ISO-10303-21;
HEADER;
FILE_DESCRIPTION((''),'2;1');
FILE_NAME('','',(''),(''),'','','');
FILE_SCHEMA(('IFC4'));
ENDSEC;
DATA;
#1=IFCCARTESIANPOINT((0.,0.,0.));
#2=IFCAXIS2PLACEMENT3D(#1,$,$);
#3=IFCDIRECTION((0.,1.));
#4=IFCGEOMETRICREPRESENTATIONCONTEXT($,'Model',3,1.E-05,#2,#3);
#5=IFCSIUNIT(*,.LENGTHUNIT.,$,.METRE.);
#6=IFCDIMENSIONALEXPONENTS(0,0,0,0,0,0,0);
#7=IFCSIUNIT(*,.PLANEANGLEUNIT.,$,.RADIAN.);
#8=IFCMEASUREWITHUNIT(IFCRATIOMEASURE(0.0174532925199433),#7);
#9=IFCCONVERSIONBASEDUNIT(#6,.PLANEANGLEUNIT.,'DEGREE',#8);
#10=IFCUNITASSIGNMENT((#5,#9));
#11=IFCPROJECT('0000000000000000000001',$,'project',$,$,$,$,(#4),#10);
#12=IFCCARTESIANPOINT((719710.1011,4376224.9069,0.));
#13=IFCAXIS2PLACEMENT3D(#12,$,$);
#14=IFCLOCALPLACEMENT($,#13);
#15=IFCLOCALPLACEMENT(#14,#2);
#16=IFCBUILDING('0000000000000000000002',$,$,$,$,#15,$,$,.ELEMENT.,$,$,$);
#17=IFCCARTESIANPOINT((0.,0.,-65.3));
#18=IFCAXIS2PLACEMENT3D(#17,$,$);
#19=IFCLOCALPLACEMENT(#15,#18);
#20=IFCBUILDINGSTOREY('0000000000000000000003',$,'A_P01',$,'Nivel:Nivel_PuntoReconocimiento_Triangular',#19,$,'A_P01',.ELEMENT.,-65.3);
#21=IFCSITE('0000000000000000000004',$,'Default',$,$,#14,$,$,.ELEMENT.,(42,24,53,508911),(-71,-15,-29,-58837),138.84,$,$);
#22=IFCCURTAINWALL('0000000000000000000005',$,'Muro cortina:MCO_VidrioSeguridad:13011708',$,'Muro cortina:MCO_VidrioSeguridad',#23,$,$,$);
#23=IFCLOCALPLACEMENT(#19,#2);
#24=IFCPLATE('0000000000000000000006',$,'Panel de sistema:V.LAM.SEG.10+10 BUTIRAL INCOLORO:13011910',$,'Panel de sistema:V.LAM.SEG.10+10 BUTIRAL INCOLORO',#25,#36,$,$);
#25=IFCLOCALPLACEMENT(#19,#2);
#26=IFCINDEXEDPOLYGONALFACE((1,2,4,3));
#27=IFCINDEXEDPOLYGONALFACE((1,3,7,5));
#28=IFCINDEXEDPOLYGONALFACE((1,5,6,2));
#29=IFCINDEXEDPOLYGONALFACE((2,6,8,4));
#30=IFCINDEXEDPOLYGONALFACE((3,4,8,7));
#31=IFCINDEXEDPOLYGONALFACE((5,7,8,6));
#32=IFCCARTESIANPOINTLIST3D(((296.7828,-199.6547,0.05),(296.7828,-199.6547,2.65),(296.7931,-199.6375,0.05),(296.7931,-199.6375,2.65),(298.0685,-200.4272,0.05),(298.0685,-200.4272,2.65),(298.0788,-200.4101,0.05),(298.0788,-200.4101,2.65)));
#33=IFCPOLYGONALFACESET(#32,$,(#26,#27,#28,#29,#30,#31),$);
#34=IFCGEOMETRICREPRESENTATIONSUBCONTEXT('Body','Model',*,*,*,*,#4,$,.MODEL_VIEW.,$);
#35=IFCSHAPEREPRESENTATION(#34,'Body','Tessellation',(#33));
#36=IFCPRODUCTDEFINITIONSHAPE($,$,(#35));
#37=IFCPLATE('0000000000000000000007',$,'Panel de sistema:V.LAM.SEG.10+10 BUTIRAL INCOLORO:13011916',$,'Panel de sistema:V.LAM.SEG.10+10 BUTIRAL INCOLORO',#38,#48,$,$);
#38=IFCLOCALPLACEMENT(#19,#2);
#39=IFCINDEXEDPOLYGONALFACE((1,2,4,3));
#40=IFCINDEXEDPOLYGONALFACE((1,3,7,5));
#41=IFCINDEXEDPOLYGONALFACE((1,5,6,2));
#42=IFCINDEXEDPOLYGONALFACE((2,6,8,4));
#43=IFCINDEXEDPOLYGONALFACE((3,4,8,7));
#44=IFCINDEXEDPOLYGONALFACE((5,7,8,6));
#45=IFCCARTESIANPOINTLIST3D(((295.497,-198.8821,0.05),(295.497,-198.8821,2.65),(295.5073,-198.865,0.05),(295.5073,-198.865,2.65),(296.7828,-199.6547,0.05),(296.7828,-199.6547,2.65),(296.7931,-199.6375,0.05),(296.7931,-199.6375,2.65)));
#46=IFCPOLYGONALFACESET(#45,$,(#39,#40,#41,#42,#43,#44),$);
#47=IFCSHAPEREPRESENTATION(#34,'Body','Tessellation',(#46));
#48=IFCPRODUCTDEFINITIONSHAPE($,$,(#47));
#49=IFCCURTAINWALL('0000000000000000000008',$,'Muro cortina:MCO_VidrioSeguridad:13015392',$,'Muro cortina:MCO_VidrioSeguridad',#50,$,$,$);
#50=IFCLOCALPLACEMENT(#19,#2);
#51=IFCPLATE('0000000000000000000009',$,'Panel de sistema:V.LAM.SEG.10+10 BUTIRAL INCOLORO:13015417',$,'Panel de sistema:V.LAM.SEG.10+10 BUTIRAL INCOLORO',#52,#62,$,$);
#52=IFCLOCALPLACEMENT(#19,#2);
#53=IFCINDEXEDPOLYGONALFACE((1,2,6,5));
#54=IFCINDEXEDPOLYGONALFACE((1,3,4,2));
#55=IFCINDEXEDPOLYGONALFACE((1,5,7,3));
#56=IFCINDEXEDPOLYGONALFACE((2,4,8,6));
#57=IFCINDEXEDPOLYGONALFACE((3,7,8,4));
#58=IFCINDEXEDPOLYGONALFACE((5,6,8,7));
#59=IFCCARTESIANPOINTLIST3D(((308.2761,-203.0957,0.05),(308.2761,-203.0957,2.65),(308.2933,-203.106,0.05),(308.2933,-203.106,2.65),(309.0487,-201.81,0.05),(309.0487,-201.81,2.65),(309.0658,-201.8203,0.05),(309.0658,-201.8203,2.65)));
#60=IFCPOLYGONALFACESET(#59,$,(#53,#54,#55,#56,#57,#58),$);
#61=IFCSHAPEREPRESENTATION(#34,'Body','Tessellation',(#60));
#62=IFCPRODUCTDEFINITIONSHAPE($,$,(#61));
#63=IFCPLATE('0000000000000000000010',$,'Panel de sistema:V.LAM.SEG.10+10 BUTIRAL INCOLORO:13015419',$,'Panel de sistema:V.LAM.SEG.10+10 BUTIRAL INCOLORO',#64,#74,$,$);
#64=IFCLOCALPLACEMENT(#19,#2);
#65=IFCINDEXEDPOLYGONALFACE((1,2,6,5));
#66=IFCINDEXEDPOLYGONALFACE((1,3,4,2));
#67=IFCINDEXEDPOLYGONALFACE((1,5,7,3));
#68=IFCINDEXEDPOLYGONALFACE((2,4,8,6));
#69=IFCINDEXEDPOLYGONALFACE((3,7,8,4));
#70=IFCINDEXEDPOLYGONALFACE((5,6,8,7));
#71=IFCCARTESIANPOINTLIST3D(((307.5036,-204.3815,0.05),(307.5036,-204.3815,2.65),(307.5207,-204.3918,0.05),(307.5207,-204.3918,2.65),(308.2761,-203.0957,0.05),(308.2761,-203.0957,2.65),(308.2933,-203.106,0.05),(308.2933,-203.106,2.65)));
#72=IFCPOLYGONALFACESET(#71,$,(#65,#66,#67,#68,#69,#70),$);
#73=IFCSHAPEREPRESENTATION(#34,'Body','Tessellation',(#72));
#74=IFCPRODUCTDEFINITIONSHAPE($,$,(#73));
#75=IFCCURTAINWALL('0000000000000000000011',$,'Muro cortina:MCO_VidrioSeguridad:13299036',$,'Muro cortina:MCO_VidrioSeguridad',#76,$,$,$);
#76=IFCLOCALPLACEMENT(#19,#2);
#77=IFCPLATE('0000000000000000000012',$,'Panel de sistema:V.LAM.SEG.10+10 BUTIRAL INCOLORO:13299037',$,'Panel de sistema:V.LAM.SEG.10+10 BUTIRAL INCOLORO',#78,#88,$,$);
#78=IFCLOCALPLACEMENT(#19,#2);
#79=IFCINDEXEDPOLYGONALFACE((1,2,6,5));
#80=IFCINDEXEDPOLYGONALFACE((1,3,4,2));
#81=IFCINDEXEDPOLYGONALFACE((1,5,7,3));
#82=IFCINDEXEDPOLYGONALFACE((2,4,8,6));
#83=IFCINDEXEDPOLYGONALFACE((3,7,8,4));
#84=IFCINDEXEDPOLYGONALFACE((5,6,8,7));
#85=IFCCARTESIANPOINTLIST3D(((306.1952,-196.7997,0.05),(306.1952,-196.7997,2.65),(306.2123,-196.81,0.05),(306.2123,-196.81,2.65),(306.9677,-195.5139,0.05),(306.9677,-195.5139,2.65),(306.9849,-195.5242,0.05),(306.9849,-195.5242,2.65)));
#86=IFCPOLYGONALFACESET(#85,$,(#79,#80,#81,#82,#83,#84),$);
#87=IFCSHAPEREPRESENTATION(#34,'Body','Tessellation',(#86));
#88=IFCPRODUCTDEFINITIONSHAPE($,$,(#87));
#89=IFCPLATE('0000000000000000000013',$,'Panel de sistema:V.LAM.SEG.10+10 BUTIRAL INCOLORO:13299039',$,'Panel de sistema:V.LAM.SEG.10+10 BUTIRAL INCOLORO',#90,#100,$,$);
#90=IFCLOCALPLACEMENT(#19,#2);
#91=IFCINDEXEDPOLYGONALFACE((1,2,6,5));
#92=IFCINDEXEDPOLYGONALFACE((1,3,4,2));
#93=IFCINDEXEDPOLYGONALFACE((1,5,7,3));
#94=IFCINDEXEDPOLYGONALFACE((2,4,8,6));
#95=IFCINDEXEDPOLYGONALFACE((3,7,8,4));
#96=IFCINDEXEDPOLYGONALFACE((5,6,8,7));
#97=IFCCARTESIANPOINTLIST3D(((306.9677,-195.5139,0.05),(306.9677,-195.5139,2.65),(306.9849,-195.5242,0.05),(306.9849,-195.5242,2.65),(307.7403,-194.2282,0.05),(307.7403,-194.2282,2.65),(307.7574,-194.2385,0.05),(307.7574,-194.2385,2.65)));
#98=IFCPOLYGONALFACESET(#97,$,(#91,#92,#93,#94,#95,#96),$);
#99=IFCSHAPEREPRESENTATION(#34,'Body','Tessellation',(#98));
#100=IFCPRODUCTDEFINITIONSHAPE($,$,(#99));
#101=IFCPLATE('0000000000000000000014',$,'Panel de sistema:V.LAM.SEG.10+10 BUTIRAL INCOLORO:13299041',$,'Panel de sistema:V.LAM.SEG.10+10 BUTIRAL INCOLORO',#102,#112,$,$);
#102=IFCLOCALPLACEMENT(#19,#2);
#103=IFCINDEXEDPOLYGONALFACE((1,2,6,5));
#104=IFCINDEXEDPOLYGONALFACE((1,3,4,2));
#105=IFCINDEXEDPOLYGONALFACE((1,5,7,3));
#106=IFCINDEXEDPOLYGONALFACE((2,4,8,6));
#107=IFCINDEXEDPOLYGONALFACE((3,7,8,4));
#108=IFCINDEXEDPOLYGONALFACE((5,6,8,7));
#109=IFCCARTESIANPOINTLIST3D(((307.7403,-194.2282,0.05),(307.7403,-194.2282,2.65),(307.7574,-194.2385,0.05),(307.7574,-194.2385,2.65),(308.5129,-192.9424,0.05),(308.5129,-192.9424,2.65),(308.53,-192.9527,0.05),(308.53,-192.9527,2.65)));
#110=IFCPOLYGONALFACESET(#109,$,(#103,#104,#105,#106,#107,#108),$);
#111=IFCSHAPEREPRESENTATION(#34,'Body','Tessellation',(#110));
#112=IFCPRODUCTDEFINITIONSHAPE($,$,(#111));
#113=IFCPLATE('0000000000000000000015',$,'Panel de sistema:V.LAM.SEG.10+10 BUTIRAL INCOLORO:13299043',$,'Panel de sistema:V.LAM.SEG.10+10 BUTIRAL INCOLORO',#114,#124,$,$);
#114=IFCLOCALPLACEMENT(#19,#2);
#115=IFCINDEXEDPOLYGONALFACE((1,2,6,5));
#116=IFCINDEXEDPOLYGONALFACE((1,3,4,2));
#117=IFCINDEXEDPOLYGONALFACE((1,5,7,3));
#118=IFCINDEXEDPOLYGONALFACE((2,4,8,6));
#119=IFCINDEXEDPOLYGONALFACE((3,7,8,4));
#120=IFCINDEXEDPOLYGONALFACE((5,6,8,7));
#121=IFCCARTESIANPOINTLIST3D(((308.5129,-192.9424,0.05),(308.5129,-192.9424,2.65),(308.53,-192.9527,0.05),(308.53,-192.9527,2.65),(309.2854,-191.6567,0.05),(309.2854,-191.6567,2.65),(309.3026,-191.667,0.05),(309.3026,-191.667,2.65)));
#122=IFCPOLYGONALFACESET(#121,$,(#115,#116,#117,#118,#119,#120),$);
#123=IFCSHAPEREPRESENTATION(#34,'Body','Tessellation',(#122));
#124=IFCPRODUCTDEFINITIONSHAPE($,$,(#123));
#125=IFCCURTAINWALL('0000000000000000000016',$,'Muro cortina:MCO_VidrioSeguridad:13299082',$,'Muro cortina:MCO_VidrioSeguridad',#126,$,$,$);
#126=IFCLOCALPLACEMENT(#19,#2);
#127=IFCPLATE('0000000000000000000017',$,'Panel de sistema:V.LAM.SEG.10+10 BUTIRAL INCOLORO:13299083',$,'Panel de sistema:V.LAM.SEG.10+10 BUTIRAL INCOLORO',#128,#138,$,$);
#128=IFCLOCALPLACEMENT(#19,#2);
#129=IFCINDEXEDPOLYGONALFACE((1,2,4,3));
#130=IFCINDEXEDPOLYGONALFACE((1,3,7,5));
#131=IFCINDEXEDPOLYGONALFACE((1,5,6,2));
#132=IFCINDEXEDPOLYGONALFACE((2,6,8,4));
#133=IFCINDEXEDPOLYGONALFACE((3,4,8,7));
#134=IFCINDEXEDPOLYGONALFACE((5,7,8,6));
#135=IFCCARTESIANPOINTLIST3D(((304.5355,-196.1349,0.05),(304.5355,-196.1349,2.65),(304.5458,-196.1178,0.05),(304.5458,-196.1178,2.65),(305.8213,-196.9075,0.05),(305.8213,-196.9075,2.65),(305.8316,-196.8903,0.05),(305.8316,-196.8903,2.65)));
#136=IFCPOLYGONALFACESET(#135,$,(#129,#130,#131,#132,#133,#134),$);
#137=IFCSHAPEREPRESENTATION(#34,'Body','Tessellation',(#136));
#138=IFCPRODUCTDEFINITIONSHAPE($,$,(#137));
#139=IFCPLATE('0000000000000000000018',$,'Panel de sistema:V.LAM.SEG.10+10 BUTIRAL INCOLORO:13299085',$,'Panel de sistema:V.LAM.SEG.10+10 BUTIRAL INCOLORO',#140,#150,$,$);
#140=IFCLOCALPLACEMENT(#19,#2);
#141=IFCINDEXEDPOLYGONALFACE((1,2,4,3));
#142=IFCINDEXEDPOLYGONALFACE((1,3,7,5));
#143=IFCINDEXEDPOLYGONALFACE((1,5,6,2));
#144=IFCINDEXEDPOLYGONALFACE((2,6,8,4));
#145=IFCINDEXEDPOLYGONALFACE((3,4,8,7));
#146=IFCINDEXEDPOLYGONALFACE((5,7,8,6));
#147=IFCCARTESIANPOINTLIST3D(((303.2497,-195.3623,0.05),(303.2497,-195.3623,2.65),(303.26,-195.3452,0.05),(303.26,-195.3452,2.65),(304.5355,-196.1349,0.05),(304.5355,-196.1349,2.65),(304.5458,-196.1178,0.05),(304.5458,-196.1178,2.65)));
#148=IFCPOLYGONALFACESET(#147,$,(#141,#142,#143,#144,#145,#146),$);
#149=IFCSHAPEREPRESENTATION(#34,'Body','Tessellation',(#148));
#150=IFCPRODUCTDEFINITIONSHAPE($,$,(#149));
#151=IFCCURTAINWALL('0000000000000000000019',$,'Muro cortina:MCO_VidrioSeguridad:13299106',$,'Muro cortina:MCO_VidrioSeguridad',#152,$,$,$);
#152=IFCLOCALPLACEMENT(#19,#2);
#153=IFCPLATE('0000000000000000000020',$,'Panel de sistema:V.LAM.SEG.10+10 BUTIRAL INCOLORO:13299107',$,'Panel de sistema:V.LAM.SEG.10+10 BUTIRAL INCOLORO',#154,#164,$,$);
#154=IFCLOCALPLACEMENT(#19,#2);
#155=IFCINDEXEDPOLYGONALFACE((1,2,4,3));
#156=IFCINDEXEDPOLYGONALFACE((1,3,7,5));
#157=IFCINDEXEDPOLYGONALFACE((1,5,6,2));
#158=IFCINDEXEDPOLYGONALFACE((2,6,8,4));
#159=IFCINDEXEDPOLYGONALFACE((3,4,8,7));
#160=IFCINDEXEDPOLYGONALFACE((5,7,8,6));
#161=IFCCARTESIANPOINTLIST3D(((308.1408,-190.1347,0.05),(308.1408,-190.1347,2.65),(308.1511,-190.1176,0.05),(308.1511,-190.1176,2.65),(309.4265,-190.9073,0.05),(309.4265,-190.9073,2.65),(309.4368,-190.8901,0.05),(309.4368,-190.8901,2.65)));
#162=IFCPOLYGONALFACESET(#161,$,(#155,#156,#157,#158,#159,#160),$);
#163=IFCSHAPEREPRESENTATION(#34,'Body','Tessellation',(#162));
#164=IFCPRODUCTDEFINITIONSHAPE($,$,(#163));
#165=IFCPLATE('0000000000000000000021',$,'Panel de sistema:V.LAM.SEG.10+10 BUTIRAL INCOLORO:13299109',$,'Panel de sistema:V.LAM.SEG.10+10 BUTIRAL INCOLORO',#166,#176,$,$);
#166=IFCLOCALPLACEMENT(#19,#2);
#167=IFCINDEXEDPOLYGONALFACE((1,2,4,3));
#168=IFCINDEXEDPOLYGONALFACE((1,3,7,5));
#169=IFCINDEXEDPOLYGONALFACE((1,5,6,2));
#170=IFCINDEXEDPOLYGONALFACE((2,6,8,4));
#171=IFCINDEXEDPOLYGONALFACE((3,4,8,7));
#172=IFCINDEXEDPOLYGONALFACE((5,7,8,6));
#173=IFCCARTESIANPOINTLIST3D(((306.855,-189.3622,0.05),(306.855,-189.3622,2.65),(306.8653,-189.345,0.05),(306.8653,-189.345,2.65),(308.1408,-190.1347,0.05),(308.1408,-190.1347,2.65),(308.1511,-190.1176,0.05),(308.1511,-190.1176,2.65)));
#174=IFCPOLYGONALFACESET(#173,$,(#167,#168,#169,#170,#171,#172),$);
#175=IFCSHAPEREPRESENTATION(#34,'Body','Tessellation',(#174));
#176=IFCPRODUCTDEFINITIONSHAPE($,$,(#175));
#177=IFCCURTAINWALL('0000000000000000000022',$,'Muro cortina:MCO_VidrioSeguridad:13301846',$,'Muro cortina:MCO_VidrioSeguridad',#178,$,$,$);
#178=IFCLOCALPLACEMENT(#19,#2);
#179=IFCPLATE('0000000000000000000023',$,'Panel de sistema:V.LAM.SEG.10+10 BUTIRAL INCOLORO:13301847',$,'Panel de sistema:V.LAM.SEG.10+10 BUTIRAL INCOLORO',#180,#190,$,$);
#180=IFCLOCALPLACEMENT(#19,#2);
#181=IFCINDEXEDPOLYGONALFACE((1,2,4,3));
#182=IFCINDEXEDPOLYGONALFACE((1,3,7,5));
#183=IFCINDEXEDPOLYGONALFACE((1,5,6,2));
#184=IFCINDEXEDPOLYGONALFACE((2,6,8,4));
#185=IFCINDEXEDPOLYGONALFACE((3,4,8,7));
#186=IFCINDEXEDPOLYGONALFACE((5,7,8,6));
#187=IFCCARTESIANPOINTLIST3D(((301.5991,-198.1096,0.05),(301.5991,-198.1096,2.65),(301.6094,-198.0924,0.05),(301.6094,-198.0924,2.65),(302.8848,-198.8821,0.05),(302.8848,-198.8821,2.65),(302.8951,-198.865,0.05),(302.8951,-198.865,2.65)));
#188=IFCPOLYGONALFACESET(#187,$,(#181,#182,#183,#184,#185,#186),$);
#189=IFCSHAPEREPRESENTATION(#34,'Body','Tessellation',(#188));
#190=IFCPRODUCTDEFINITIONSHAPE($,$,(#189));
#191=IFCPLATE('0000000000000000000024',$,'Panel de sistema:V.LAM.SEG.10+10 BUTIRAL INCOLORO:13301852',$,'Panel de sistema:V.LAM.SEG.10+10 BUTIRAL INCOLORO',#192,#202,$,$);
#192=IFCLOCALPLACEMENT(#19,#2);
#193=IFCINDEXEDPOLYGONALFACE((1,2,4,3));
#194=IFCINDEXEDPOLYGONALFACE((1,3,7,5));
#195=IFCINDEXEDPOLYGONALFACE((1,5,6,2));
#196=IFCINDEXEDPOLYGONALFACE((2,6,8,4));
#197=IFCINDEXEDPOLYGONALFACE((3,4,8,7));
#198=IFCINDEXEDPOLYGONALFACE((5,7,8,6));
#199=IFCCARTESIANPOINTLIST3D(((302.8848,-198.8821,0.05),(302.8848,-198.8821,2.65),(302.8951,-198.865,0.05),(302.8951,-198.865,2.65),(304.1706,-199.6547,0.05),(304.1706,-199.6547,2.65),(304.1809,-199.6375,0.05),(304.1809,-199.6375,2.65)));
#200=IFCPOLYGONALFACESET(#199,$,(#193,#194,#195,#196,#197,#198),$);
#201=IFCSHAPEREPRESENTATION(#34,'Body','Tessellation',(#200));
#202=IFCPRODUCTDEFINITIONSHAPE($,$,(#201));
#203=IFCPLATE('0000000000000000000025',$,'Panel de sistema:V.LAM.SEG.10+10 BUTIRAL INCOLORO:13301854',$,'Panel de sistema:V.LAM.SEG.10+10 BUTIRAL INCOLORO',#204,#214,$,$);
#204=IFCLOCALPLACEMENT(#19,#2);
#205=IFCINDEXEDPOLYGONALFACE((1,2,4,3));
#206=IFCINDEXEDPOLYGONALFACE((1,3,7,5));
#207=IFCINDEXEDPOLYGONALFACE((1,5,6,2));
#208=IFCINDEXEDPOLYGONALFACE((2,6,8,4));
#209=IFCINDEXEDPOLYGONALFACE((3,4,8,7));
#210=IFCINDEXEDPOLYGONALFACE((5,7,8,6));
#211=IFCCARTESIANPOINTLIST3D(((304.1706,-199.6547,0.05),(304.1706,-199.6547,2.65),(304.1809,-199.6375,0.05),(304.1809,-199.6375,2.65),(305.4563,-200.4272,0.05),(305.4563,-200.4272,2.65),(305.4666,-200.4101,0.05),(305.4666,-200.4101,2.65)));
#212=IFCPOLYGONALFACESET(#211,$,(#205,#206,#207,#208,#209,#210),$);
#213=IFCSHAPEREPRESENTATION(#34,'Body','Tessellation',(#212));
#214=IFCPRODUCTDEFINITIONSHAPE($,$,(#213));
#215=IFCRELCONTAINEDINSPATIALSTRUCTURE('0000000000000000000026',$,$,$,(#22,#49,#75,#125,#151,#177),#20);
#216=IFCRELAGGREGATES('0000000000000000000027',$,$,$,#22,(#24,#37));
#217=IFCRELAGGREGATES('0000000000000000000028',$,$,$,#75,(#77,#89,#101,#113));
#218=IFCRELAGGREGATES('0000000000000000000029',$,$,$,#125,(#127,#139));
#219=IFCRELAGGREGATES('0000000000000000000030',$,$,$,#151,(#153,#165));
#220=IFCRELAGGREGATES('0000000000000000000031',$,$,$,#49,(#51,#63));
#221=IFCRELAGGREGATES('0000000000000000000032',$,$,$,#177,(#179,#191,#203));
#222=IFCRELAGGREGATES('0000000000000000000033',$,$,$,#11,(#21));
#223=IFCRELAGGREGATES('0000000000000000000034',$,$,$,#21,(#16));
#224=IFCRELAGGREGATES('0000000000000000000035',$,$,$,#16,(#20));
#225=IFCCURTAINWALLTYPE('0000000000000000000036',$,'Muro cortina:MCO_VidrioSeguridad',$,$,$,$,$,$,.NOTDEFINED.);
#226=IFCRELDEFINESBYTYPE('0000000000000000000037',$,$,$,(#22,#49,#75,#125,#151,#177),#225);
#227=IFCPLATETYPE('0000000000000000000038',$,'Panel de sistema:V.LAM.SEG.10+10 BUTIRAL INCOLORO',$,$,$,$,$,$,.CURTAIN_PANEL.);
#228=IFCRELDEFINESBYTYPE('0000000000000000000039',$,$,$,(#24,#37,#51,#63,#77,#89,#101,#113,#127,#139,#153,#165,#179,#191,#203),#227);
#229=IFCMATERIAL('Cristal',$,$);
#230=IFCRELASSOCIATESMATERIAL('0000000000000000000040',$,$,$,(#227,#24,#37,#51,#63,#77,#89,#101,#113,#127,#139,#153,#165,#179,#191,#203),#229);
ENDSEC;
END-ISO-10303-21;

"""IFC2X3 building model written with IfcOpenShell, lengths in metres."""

from ifc_helpers import new_model, entity, si_unit, converted_unit, direction, frame, origin, origin_2d_with_axis, place, context, subcontext, project, spatial, rectangle, extrude, source, transform, mapped, material, type_object, type_shapes, element, aggregate, save


model = new_model("IFC2X3")

# Units and contexts
model_context = context("Model", 3, precision=1e-05, world=origin(), true_north=direction((0.0, 1.0)))
body_context = subcontext(model_context, "Body", "Model", "MODEL_VIEW")
ifc_project = project(units=[si_unit("LENGTHUNIT", "METRE"), converted_unit("PLANEANGLEUNIT", "DEGREE", entity("IfcRatioMeasure", 0.0174532925199433), si_unit("PLANEANGLEUNIT", "RADIAN"), dimensions=[0, 0, 0, 0, 0, 0, 0])], contexts=[model_context])

# Site, building, storey
site_placement = place(None, frame((719710.1011, 4376224.9069, 0.0)))
site = spatial("IfcSite", under=ifc_project, at=site_placement, Name="Default", CompositionType="ELEMENT", RefLatitude=(42, 24, 53, 508911), RefLongitude=(-71, -15, -29, -58837), RefElevation=138.84)
building_placement = place(site_placement, origin())
building = spatial("IfcBuilding", under=site, at=building_placement, CompositionType="ELEMENT")
storey_placement = place(building_placement, frame((0.0, 0.0, -65.3)))
storey = spatial("IfcBuildingStorey", under=building, at=storey_placement, Name="A_P01", ObjectType="Nivel:Nivel_PuntoReconocimiento_Triangular", LongName="A_P01", CompositionType="ELEMENT", Elevation=-65.3)

# Curtain walls, plates
curtain_wall_type = type_object("IfcCurtainWallType", Name="Muro cortina:MCO_VidrioSeguridad", PredefinedType="NOTDEFINED")
curtain_wall_1_placement = place(storey_placement, frame((0.0, 0.0, 65.3)))
curtain_wall_1 = element("IfcCurtainWall", 1, at=curtain_wall_1_placement, inside=storey, type_object=curtain_wall_type, Name="Muro cortina:MCO_VidrioSeguridad:13011708", ObjectType="Muro cortina:MCO_VidrioSeguridad")
ifc_material_1 = material(Name="Cristal")
plate_type_1 = type_object("IfcPlateType", Name="Panel de sistema:V.LAM.SEG.10+10 BUTIRAL INCOLORO", PredefinedType="CURTAIN_PANEL", material=ifc_material_1)
shared_shape_1 = source(origin(), body_context, "Body", "SweptSolid", [
    extrude(rectangle(XDim=0.02, YDim=1.5, at=origin_2d_with_axis()), frame((0.0, 0.0, 0.0), z_axis=(0.0, 0.0, 1.0), x_axis=(0.0, 1.0, 0.0)), (0.0, 0.0, 1.0), 2.6),
])
type_shapes(plate_type_1, [shared_shape_1])
plate_1_placement = place(curtain_wall_1_placement, frame((297.4308, -200.0324, -65.25), z_axis=(0.0, 0.0, 1.0), x_axis=(-0.857167, 0.515038, 0.0)))
plate_1 = element("IfcPlate", 2, at=plate_1_placement, type_object=plate_type_1, material=ifc_material_1, Name="Panel de sistema:V.LAM.SEG.10+10 BUTIRAL INCOLORO:13011910", ObjectType="Panel de sistema:V.LAM.SEG.10+10 BUTIRAL INCOLORO", context=body_context, shape_type="MappedRepresentation", body=[
    mapped(shared_shape_1, transform((0.0, 0.0, 0.0), scale=1.0)),
])
plate_2_placement = place(curtain_wall_1_placement, frame((296.145, -199.2598, -65.25), z_axis=(0.0, 0.0, 1.0), x_axis=(-0.857167, 0.515038, 0.0)))
plate_2 = element("IfcPlate", 3, at=plate_2_placement, type_object=plate_type_1, material=ifc_material_1, Name="Panel de sistema:V.LAM.SEG.10+10 BUTIRAL INCOLORO:13011916", ObjectType="Panel de sistema:V.LAM.SEG.10+10 BUTIRAL INCOLORO", context=body_context, shape_type="MappedRepresentation", body=[
    mapped(shared_shape_1, transform((0.0, 0.0, 0.0), scale=1.0)),
])
aggregate(curtain_wall_1, [plate_1, plate_2])
curtain_wall_2_placement = place(storey_placement, frame((0.0, 0.0, 65.3)))
curtain_wall_2 = element("IfcCurtainWall", 4, at=curtain_wall_2_placement, inside=storey, type_object=curtain_wall_type, Name="Muro cortina:MCO_VidrioSeguridad:13015392", ObjectType="Muro cortina:MCO_VidrioSeguridad")
plate_3_placement = place(curtain_wall_2_placement, frame((308.671, -202.458, -65.25), z_axis=(0.0, 0.0, 1.0), x_axis=(-0.515038, -0.857167, 0.0)))
plate_3 = element("IfcPlate", 5, at=plate_3_placement, type_object=plate_type_1, material=ifc_material_1, Name="Panel de sistema:V.LAM.SEG.10+10 BUTIRAL INCOLORO:13015417", ObjectType="Panel de sistema:V.LAM.SEG.10+10 BUTIRAL INCOLORO", context=body_context, shape_type="MappedRepresentation", body=[
    mapped(shared_shape_1, transform((0.0, 0.0, 0.0), scale=1.0)),
])
plate_4_placement = place(curtain_wall_2_placement, frame((307.8984, -203.7437, -65.25), z_axis=(0.0, 0.0, 1.0), x_axis=(-0.515038, -0.857167, 0.0)))
plate_4 = element("IfcPlate", 6, at=plate_4_placement, type_object=plate_type_1, material=ifc_material_1, Name="Panel de sistema:V.LAM.SEG.10+10 BUTIRAL INCOLORO:13015419", ObjectType="Panel de sistema:V.LAM.SEG.10+10 BUTIRAL INCOLORO", context=body_context, shape_type="MappedRepresentation", body=[
    mapped(shared_shape_1, transform((0.0, 0.0, 0.0), scale=1.0)),
])
curtain_wall_3_placement = place(storey_placement, frame((0.0, 0.0, 65.3)))
curtain_wall_3 = element("IfcCurtainWall", 7, at=curtain_wall_3_placement, inside=storey, type_object=curtain_wall_type, Name="Muro cortina:MCO_VidrioSeguridad:13299036", ObjectType="Muro cortina:MCO_VidrioSeguridad")
plate_5_placement = place(curtain_wall_3_placement, frame((306.59, -196.1619, -65.25), z_axis=(0.0, 0.0, 1.0), x_axis=(0.515038, 0.857167, 0.0)))
plate_5 = element("IfcPlate", 8, at=plate_5_placement, type_object=plate_type_1, material=ifc_material_1, Name="Panel de sistema:V.LAM.SEG.10+10 BUTIRAL INCOLORO:13299037", ObjectType="Panel de sistema:V.LAM.SEG.10+10 BUTIRAL INCOLORO", context=body_context, shape_type="MappedRepresentation", body=[
    mapped(shared_shape_1, transform((0.0, 0.0, 0.0), scale=1.0)),
])
plate_6_placement = place(curtain_wall_3_placement, frame((307.3626, -194.8762, -65.25), z_axis=(0.0, 0.0, 1.0), x_axis=(0.515038, 0.857167, 0.0)))
plate_6 = element("IfcPlate", 9, at=plate_6_placement, type_object=plate_type_1, material=ifc_material_1, Name="Panel de sistema:V.LAM.SEG.10+10 BUTIRAL INCOLORO:13299039", ObjectType="Panel de sistema:V.LAM.SEG.10+10 BUTIRAL INCOLORO", context=body_context, shape_type="MappedRepresentation", body=[
    mapped(shared_shape_1, transform((0.0, 0.0, 0.0), scale=1.0)),
])
plate_7_placement = place(curtain_wall_3_placement, frame((308.1352, -193.5904, -65.25), z_axis=(0.0, 0.0, 1.0), x_axis=(0.515038, 0.857167, 0.0)))
plate_7 = element("IfcPlate", 10, at=plate_7_placement, type_object=plate_type_1, material=ifc_material_1, Name="Panel de sistema:V.LAM.SEG.10+10 BUTIRAL INCOLORO:13299041", ObjectType="Panel de sistema:V.LAM.SEG.10+10 BUTIRAL INCOLORO", context=body_context, shape_type="MappedRepresentation", body=[
    mapped(shared_shape_1, transform((0.0, 0.0, 0.0), scale=1.0)),
])
plate_8_placement = place(curtain_wall_3_placement, frame((308.9077, -192.3047, -65.25), z_axis=(0.0, 0.0, 1.0), x_axis=(0.515038, 0.857167, 0.0)))
plate_8 = element("IfcPlate", 11, at=plate_8_placement, type_object=plate_type_1, material=ifc_material_1, Name="Panel de sistema:V.LAM.SEG.10+10 BUTIRAL INCOLORO:13299043", ObjectType="Panel de sistema:V.LAM.SEG.10+10 BUTIRAL INCOLORO", context=body_context, shape_type="MappedRepresentation", body=[
    mapped(shared_shape_1, transform((0.0, 0.0, 0.0), scale=1.0)),
])
aggregate(curtain_wall_3, [plate_5, plate_6, plate_7, plate_8])
curtain_wall_4_placement = place(storey_placement, frame((0.0, 0.0, 65.3)))
curtain_wall_4 = element("IfcCurtainWall", 12, at=curtain_wall_4_placement, inside=storey, type_object=curtain_wall_type, Name="Muro cortina:MCO_VidrioSeguridad:13299082", ObjectType="Muro cortina:MCO_VidrioSeguridad")
plate_9_placement = place(curtain_wall_4_placement, frame((305.1835, -196.5126, -65.25), z_axis=(0.0, 0.0, 1.0), x_axis=(-0.857167, 0.515038, 0.0)))
plate_9 = element("IfcPlate", 13, at=plate_9_placement, type_object=plate_type_1, material=ifc_material_1, Name="Panel de sistema:V.LAM.SEG.10+10 BUTIRAL INCOLORO:13299083", ObjectType="Panel de sistema:V.LAM.SEG.10+10 BUTIRAL INCOLORO", context=body_context, shape_type="MappedRepresentation", body=[
    mapped(shared_shape_1, transform((0.0, 0.0, 0.0), scale=1.0)),
])
plate_10_placement = place(curtain_wall_4_placement, frame((303.8978, -195.7401, -65.25), z_axis=(0.0, 0.0, 1.0), x_axis=(-0.857167, 0.515038, 0.0)))
plate_10 = element("IfcPlate", 14, at=plate_10_placement, type_object=plate_type_1, material=ifc_material_1, Name="Panel de sistema:V.LAM.SEG.10+10 BUTIRAL INCOLORO:13299085", ObjectType="Panel de sistema:V.LAM.SEG.10+10 BUTIRAL INCOLORO", context=body_context, shape_type="MappedRepresentation", body=[
    mapped(shared_shape_1, transform((0.0, 0.0, 0.0), scale=1.0)),
])
aggregate(curtain_wall_4, [plate_9, plate_10])
curtain_wall_5_placement = place(storey_placement, frame((0.0, 0.0, 65.3)))
curtain_wall_5 = element("IfcCurtainWall", 15, at=curtain_wall_5_placement, inside=storey, type_object=curtain_wall_type, Name="Muro cortina:MCO_VidrioSeguridad:13299106", ObjectType="Muro cortina:MCO_VidrioSeguridad")
plate_11_placement = place(curtain_wall_5_placement, frame((308.7888, -190.5124, -65.25), z_axis=(0.0, 0.0, 1.0), x_axis=(-0.857167, 0.515038, 0.0)))
plate_11 = element("IfcPlate", 16, at=plate_11_placement, type_object=plate_type_1, material=ifc_material_1, Name="Panel de sistema:V.LAM.SEG.10+10 BUTIRAL INCOLORO:13299107", ObjectType="Panel de sistema:V.LAM.SEG.10+10 BUTIRAL INCOLORO", context=body_context, shape_type="MappedRepresentation", body=[
    mapped(shared_shape_1, transform((0.0, 0.0, 0.0), scale=1.0)),
])
plate_12_placement = place(curtain_wall_5_placement, frame((307.503, -189.7399, -65.25), z_axis=(0.0, 0.0, 1.0), x_axis=(-0.857167, 0.515038, 0.0)))
plate_12 = element("IfcPlate", 17, at=plate_12_placement, type_object=plate_type_1, material=ifc_material_1, Name="Panel de sistema:V.LAM.SEG.10+10 BUTIRAL INCOLORO:13299109", ObjectType="Panel de sistema:V.LAM.SEG.10+10 BUTIRAL INCOLORO", context=body_context, shape_type="MappedRepresentation", body=[
    mapped(shared_shape_1, transform((0.0, 0.0, 0.0), scale=1.0)),
])
aggregate(curtain_wall_5, [plate_11, plate_12])
curtain_wall_6_placement = place(storey_placement, frame((0.0, 0.0, 65.3)))
curtain_wall_6 = element("IfcCurtainWall", 18, at=curtain_wall_6_placement, inside=storey, type_object=curtain_wall_type, Name="Muro cortina:MCO_VidrioSeguridad:13301846", ObjectType="Muro cortina:MCO_VidrioSeguridad")
plate_13_placement = place(curtain_wall_6_placement, frame((302.2471, -198.4873, -65.25), z_axis=(0.0, 0.0, 1.0), x_axis=(0.857167, -0.515038, 0.0)))
plate_13 = element("IfcPlate", 19, at=plate_13_placement, type_object=plate_type_1, material=ifc_material_1, Name="Panel de sistema:V.LAM.SEG.10+10 BUTIRAL INCOLORO:13301847", ObjectType="Panel de sistema:V.LAM.SEG.10+10 BUTIRAL INCOLORO", context=body_context, shape_type="MappedRepresentation", body=[
    mapped(shared_shape_1, transform((0.0, 0.0, 0.0), scale=1.0)),
])
plate_14_placement = place(curtain_wall_6_placement, frame((303.5328, -199.2598, -65.25), z_axis=(0.0, 0.0, 1.0), x_axis=(0.857167, -0.515038, 0.0)))
plate_14 = element("IfcPlate", 20, at=plate_14_placement, type_object=plate_type_1, material=ifc_material_1, Name="Panel de sistema:V.LAM.SEG.10+10 BUTIRAL INCOLORO:13301852", ObjectType="Panel de sistema:V.LAM.SEG.10+10 BUTIRAL INCOLORO", context=body_context, shape_type="MappedRepresentation", body=[
    mapped(shared_shape_1, transform((0.0, 0.0, 0.0), scale=1.0)),
])
plate_15_placement = place(curtain_wall_6_placement, frame((304.8186, -200.0324, -65.25), z_axis=(0.0, 0.0, 1.0), x_axis=(0.857167, -0.515038, 0.0)))
plate_15 = element("IfcPlate", 21, at=plate_15_placement, type_object=plate_type_1, material=ifc_material_1, Name="Panel de sistema:V.LAM.SEG.10+10 BUTIRAL INCOLORO:13301854", ObjectType="Panel de sistema:V.LAM.SEG.10+10 BUTIRAL INCOLORO", context=body_context, shape_type="MappedRepresentation", body=[
    mapped(shared_shape_1, transform((0.0, 0.0, 0.0), scale=1.0)),
])

aggregate(curtain_wall_2, [plate_3, plate_4])
aggregate(curtain_wall_6, [plate_13, plate_14, plate_15])

save(model, "model.ifc")
